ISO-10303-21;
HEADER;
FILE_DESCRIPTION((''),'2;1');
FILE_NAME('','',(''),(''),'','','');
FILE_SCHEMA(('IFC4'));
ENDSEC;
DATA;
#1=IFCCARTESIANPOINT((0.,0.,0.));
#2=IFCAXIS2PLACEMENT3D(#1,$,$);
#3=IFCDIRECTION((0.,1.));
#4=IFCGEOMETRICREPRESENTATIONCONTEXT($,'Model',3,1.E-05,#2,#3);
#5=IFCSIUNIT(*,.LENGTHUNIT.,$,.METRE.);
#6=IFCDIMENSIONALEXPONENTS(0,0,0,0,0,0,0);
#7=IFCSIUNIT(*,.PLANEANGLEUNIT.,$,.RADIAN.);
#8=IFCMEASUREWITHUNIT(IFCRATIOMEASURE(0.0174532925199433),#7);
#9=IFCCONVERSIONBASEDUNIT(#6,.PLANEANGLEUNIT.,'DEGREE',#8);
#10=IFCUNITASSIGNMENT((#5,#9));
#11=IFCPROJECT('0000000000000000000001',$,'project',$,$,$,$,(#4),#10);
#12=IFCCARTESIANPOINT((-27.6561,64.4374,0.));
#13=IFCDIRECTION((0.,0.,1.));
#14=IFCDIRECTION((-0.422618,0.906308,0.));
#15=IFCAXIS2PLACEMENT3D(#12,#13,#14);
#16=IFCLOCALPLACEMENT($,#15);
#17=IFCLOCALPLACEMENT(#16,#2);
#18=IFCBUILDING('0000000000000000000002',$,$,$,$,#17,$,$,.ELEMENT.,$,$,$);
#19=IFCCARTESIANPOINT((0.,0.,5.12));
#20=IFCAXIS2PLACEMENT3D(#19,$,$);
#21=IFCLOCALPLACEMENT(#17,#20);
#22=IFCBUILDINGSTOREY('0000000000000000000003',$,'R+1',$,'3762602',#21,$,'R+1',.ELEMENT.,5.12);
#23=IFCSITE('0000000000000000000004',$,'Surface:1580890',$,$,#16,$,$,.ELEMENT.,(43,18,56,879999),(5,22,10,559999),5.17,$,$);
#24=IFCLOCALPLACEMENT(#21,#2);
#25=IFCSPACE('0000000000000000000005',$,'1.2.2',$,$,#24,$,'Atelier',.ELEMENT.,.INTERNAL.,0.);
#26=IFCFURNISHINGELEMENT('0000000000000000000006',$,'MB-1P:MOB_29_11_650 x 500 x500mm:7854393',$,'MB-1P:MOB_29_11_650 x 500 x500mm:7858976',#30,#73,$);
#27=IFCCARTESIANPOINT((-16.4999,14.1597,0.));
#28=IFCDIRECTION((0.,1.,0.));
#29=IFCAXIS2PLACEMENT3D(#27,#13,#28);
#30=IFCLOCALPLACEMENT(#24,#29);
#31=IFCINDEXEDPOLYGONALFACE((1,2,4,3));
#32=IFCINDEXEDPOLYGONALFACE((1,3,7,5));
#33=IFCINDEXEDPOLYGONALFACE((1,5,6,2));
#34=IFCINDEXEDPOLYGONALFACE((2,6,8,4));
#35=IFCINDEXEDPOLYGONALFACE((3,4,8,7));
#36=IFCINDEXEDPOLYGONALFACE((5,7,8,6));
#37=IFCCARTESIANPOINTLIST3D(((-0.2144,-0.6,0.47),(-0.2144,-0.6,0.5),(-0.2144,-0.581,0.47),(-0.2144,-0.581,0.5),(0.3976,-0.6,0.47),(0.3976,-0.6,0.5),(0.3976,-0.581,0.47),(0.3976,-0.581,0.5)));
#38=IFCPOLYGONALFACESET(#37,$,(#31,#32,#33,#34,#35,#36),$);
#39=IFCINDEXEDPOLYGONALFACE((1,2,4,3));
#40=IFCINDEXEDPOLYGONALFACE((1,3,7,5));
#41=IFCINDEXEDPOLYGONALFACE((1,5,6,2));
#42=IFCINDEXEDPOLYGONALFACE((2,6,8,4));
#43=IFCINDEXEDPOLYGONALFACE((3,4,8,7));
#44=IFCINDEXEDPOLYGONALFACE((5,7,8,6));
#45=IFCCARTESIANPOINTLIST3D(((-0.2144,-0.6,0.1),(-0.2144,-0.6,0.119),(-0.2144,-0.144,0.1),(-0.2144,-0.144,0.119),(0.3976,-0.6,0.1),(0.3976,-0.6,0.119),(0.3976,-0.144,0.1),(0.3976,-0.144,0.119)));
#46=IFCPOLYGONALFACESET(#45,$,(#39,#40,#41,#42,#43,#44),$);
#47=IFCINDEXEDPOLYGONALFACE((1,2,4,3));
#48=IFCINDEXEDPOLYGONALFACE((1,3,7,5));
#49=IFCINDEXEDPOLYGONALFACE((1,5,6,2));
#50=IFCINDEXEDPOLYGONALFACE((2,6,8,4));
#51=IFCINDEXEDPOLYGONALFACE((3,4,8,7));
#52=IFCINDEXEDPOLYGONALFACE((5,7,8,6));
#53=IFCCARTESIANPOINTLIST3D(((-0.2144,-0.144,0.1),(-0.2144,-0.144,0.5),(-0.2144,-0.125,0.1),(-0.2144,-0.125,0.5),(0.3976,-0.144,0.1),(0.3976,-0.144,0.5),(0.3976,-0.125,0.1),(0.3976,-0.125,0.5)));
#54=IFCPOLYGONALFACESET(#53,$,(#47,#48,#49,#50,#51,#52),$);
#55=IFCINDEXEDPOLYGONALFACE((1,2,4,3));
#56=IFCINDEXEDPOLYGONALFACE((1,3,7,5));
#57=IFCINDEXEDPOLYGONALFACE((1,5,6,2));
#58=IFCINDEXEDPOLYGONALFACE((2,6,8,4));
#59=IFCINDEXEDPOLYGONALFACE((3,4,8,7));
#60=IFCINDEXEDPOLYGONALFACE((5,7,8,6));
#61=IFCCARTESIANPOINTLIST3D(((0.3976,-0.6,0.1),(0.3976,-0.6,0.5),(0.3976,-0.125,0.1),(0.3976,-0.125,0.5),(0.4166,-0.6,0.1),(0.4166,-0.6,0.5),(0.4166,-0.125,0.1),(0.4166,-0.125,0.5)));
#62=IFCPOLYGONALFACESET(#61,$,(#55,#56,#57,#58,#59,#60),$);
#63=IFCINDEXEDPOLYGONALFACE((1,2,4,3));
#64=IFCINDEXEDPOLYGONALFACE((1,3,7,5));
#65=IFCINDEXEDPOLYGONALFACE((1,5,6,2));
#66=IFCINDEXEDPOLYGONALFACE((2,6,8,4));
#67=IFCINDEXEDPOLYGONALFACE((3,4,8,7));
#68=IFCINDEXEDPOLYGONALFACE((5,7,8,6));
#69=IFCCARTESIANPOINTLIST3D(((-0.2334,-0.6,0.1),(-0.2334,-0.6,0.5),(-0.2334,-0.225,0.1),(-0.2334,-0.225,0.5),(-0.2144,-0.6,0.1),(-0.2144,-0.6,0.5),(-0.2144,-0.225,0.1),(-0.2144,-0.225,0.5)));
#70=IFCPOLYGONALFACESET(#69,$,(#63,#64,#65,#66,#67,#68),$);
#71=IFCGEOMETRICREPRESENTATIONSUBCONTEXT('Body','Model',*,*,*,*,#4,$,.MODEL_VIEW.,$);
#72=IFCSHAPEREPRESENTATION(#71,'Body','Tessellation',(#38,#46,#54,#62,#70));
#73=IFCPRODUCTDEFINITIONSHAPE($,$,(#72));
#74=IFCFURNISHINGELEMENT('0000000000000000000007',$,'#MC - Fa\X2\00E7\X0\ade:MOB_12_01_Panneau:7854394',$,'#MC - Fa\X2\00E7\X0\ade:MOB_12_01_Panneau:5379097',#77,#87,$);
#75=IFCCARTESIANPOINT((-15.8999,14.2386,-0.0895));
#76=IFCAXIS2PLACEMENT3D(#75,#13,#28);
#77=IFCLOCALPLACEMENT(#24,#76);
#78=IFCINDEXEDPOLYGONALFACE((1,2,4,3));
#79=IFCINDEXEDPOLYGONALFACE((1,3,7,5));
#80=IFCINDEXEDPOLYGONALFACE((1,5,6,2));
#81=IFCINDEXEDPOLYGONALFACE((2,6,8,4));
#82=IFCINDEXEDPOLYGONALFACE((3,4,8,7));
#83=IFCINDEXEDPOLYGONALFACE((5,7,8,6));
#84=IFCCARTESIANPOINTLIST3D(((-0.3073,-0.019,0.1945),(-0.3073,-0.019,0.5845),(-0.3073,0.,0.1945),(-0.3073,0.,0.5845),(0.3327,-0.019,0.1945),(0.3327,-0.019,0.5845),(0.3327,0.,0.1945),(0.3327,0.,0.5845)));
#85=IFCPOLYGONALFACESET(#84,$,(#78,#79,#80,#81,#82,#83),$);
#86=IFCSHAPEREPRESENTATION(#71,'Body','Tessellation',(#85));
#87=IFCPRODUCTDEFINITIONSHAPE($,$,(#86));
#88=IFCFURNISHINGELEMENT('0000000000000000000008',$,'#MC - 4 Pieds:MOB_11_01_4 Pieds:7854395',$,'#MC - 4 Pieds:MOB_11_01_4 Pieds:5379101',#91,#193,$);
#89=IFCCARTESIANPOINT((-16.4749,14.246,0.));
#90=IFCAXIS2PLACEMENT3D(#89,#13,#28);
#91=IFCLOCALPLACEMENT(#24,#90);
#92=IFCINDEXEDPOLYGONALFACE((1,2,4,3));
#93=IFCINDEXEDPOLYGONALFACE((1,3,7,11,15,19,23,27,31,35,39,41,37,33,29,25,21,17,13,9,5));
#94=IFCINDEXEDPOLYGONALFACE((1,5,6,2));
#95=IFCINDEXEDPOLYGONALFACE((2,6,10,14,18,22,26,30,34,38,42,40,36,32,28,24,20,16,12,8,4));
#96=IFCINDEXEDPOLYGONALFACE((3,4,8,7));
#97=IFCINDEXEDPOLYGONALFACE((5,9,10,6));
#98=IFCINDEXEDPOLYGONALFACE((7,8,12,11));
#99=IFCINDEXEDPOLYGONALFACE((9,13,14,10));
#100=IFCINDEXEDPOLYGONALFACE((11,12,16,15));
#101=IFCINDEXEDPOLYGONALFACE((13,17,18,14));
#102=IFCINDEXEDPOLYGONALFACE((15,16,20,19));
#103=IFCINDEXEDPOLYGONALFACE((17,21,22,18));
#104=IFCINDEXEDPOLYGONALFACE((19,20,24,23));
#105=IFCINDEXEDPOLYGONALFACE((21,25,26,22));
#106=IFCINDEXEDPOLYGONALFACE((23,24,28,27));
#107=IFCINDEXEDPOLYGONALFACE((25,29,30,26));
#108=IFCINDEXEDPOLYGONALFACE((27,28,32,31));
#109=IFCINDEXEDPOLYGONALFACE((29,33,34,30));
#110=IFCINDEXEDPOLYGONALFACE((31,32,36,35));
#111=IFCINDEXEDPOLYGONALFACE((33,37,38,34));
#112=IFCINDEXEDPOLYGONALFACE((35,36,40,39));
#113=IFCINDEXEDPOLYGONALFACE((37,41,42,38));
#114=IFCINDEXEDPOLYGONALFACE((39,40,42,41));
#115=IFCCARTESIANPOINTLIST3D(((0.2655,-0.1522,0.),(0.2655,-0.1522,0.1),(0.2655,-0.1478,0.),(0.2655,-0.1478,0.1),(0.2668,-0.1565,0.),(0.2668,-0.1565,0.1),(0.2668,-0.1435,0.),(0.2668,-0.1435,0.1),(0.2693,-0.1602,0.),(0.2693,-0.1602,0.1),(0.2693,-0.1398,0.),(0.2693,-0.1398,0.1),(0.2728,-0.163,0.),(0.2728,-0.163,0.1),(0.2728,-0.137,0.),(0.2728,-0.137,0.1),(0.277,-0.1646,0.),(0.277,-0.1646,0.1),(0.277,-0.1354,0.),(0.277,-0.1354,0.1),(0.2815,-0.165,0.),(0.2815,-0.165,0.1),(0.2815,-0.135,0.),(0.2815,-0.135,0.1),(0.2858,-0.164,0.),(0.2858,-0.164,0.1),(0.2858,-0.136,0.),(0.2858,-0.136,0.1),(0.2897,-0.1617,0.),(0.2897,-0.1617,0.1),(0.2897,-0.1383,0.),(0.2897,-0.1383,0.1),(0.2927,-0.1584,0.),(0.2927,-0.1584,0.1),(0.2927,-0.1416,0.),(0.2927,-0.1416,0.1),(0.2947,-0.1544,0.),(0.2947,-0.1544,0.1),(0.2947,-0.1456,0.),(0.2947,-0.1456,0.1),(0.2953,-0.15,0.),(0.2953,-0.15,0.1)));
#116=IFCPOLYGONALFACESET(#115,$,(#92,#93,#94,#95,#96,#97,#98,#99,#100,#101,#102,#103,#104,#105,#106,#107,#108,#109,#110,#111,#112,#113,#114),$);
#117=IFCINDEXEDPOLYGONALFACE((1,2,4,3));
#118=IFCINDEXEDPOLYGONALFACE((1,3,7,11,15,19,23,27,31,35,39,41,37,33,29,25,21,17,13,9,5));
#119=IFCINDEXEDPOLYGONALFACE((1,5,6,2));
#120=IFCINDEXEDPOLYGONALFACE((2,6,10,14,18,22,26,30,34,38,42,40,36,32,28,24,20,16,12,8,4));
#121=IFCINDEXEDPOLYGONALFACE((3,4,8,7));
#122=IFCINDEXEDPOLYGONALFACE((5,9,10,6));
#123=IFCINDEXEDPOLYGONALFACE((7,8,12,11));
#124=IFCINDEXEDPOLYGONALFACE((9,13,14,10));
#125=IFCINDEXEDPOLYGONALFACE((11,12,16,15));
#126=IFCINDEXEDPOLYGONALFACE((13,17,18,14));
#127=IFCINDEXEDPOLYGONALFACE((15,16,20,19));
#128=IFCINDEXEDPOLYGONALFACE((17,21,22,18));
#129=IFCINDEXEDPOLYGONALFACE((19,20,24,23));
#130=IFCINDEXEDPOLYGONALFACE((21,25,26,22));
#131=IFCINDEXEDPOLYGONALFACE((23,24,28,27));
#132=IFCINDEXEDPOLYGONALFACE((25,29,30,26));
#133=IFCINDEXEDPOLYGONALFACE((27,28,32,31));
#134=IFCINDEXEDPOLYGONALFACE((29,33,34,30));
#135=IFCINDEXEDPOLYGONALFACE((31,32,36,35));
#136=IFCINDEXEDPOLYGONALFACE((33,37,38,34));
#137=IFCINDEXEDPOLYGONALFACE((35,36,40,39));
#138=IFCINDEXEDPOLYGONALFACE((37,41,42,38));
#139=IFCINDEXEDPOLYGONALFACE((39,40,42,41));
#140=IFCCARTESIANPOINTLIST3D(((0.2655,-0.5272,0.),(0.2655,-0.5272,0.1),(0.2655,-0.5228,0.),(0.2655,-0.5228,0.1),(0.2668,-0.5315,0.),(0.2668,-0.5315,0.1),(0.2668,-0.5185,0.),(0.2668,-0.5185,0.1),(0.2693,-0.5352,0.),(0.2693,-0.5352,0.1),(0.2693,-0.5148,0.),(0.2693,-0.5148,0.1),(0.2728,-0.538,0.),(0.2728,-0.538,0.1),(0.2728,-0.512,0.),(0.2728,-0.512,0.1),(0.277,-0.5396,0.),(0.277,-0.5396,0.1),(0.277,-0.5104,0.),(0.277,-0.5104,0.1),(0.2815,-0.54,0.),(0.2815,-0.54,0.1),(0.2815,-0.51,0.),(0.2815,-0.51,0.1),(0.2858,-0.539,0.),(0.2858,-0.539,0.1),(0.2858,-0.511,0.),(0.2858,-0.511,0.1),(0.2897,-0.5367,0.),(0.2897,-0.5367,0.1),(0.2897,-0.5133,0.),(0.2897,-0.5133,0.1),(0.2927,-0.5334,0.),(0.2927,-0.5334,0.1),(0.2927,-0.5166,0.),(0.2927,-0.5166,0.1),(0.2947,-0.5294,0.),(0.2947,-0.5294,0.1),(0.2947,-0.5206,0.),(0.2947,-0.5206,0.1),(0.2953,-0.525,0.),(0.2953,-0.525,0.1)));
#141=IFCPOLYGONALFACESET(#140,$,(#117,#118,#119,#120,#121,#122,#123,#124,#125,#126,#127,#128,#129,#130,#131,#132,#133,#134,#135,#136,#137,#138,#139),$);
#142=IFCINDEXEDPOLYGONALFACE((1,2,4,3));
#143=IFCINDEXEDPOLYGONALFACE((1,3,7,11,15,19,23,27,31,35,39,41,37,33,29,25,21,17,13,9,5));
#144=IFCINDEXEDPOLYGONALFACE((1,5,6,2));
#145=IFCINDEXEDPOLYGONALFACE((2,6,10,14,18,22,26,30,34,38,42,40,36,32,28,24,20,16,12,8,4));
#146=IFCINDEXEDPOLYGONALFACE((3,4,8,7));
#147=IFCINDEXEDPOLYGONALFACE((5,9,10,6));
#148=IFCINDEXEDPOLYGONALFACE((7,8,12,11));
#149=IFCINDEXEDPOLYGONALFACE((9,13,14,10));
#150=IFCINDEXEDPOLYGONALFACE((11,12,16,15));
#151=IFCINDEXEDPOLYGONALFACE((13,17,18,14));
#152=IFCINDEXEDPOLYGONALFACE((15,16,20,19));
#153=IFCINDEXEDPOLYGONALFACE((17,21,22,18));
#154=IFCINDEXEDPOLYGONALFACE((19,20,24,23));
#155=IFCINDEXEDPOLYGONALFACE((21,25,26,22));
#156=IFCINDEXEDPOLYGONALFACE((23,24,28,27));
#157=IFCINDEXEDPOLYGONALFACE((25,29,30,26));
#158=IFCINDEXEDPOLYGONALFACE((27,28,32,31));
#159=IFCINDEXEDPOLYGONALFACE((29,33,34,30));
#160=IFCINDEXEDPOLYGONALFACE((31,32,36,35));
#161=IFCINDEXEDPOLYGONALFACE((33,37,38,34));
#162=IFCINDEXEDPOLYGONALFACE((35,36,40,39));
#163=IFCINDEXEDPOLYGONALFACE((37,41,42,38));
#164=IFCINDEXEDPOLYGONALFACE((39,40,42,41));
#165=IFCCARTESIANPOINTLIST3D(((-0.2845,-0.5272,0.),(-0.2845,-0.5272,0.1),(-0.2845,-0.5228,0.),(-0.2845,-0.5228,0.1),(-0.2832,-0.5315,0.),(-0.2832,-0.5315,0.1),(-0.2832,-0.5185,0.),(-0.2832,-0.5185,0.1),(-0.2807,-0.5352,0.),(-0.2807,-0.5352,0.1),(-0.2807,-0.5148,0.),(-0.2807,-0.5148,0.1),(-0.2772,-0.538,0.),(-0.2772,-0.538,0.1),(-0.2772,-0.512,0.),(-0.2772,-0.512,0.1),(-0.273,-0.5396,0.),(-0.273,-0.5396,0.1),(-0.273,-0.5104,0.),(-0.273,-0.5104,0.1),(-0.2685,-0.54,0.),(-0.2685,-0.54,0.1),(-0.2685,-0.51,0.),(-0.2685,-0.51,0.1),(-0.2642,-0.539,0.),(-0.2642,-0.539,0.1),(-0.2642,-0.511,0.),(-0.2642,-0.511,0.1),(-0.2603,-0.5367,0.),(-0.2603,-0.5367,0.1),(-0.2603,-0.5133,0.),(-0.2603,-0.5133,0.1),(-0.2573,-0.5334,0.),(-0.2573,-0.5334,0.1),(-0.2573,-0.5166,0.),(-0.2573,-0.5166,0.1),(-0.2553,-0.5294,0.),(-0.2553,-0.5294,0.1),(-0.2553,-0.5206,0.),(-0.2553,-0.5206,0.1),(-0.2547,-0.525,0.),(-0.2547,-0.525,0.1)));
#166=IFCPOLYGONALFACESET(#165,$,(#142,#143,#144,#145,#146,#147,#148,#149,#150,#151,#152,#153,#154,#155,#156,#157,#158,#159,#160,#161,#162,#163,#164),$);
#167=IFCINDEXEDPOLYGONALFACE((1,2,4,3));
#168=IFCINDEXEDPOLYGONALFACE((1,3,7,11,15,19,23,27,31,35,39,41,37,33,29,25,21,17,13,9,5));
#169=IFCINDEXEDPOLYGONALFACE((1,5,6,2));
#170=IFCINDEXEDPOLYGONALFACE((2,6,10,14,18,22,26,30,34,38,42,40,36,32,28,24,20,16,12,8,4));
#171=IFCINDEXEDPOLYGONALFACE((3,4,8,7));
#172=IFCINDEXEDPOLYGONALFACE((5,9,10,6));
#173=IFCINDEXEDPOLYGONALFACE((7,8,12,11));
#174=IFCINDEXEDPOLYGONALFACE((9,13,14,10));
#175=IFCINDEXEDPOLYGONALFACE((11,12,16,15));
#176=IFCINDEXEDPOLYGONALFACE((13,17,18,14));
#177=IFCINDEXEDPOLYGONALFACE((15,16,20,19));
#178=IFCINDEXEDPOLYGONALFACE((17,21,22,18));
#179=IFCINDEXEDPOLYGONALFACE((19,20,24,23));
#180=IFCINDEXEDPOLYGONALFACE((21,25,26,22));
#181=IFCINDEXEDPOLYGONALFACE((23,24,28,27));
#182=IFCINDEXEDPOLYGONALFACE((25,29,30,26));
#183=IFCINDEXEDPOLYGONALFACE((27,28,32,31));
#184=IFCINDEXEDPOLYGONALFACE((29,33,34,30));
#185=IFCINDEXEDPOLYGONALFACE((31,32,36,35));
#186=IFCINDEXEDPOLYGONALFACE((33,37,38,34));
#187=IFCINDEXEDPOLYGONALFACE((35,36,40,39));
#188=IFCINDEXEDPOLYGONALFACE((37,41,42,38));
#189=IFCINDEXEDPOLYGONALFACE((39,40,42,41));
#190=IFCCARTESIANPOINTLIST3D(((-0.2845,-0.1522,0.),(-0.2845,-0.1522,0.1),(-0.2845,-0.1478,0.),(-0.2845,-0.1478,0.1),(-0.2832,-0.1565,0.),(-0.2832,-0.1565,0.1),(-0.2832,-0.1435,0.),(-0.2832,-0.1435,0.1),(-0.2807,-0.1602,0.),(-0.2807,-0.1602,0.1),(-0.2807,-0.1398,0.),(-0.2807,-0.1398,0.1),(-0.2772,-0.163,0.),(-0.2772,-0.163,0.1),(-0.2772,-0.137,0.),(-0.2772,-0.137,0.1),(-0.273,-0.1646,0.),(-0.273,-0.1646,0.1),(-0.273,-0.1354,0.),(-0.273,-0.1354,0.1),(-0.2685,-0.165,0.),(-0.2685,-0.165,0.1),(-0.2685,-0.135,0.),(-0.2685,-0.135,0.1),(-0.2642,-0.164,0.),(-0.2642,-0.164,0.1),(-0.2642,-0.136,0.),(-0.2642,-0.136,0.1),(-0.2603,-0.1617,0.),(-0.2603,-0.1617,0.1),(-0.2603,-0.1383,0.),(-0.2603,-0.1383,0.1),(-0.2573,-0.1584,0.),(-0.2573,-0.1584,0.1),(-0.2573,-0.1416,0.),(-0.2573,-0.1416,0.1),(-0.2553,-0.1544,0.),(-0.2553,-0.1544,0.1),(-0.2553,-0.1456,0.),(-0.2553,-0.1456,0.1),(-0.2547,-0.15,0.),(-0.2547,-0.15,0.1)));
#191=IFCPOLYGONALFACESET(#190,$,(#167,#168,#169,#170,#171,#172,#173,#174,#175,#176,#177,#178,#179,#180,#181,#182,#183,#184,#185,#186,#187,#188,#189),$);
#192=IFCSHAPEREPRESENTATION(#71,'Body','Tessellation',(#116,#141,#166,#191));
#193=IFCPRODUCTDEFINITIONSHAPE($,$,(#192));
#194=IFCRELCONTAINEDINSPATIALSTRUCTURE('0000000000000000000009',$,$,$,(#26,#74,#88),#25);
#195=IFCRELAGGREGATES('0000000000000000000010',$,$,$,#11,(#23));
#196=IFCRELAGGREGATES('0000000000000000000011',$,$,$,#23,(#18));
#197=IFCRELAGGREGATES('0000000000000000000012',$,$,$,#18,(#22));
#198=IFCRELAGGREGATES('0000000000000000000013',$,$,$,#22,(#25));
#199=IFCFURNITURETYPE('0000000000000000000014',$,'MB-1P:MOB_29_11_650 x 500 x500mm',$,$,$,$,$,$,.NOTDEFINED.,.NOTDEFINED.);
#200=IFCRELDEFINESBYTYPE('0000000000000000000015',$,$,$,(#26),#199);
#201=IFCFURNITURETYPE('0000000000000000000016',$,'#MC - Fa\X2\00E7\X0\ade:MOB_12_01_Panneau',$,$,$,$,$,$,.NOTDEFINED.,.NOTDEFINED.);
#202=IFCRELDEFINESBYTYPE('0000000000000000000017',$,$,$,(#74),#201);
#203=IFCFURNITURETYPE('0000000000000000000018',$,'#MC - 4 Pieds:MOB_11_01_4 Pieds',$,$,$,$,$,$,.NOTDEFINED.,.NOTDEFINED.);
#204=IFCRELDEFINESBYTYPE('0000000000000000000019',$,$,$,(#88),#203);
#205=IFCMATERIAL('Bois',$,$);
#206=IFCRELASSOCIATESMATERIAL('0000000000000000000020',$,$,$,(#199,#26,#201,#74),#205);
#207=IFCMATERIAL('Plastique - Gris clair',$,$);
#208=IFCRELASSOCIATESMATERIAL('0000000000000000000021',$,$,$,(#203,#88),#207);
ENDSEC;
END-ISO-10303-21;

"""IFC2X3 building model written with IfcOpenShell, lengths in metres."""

from ifc_helpers import new_model, entity, si_unit, converted_unit, direction, frame, frame_2d, origin, origin_2d_with_axis, place, context, subcontext, project, spatial, rectangle, circle, extrude, source, transform, mapped, material, type_object, type_shapes, element, save


model = new_model("IFC2X3")

# Units and contexts
model_context = context("Model", 3, precision=1e-05, world=origin(), true_north=direction((0.0, 1.0)))
body_context = subcontext(model_context, "Body", "Model", "MODEL_VIEW")
ifc_project = project(units=[si_unit("LENGTHUNIT", "METRE"), converted_unit("PLANEANGLEUNIT", "DEGREE", entity("IfcRatioMeasure", 0.0174532925199433), si_unit("PLANEANGLEUNIT", "RADIAN"), dimensions=[0, 0, 0, 0, 0, 0, 0])], contexts=[model_context])

# Site, building, storey
site_placement = place(None, frame((-27.6561, 64.4374, 0.0), z_axis=(0.0, 0.0, 1.0), x_axis=(-0.422618, 0.906308, 0.0)))
site = spatial("IfcSite", under=ifc_project, at=site_placement, Name="Surface:1580890", CompositionType="ELEMENT", RefLatitude=(43, 18, 56, 879999), RefLongitude=(5, 22, 10, 559999), RefElevation=5.17)
building_placement = place(site_placement, origin())
building = spatial("IfcBuilding", under=site, at=building_placement, CompositionType="ELEMENT")
storey_placement = place(building_placement, frame((0.0, 0.0, 5.12)))
storey = spatial("IfcBuildingStorey", under=building, at=storey_placement, Name="R+1", ObjectType="3762602", LongName="R+1", CompositionType="ELEMENT", Elevation=5.12)

# Shared definitions
space_placement = place(storey_placement, origin())
space = spatial("IfcSpace", under=storey, at=space_placement, Name="1.2.2", LongName="Atelier", CompositionType="ELEMENT", InteriorOrExteriorSpace="INTERNAL", ElevationWithFlooring=0.0)

# Furnishing elements
ifc_material_1 = material(Name="Plastique - Gris clair")
ifc_material_2 = material(Name="Bois")
furniture_type_1 = type_object("IfcFurnitureType", Name="MB-1P:MOB_29_11_650 x 500 x500mm", material=ifc_material_2)
shared_shape_1 = source(origin(), body_context, "Body", "SweptSolid", [
    extrude(rectangle(XDim=0.612, YDim=0.019, at=origin_2d_with_axis()), frame((0.0916, -0.5905, 0.47), z_axis=(0.0, 0.0, 1.0), x_axis=(-1.0, 0.0, 0.0)), (0.0, 0.0, 1.0), 0.03),
    extrude(rectangle(XDim=0.456, YDim=0.612, at=frame_2d((0.0, 0.0), x_axis=(1.0, 0.0))), frame((0.0916, -0.372, 0.1), z_axis=(0.0, 0.0, 1.0), x_axis=(0.0, 1.0, 0.0)), (0.0, 0.0, 1.0), 0.019),
    extrude(rectangle(XDim=0.612, YDim=0.019, at=origin_2d_with_axis()), frame((0.0916, -0.1345, 0.1), z_axis=(0.0, 0.0, 1.0), x_axis=(-1.0, 0.0, 0.0)), (0.0, 0.0, 1.0), 0.4),
    extrude(rectangle(XDim=0.475, YDim=0.019, at=origin_2d_with_axis()), frame((0.4071, -0.3625, 0.1), z_axis=(0.0, 0.0, 1.0), x_axis=(0.0, 1.0, 0.0)), (0.0, 0.0, 1.0), 0.4),
    extrude(rectangle(XDim=0.375, YDim=0.019, at=origin_2d_with_axis()), frame((-0.2239, -0.4125, 0.1), z_axis=(0.0, 0.0, 1.0), x_axis=(0.0, 1.0, 0.0)), (0.0, 0.0, 1.0), 0.4),
])
type_shapes(furniture_type_1, [shared_shape_1])
furnishing_1_placement = place(space_placement, frame((-16.4999, 14.1597, 0.0), z_axis=(0.0, 0.0, 1.0), x_axis=(0.0, 1.0, 0.0)))
element("IfcFurnishingElement", 1, at=furnishing_1_placement, inside=space, type_object=furniture_type_1, material=ifc_material_2, Name="MB-1P:MOB_29_11_650 x 500 x500mm:7854393", ObjectType="MB-1P:MOB_29_11_650 x 500 x500mm:7858976", context=body_context, shape_type="MappedRepresentation", body=[
    mapped(shared_shape_1, transform((0.0, 0.0, 0.0), scale=1.0)),
])
furniture_type_2 = type_object("IfcFurnitureType", Name="#MC - Façade:MOB_12_01_Panneau", material=ifc_material_2)
shared_shape_2 = source(origin(), body_context, "Body", "SweptSolid", [
    extrude(rectangle(XDim=0.64, YDim=0.019, at=origin_2d_with_axis()), frame((0.0127, -0.0095, 0.1945), z_axis=(0.0, 0.0, 1.0), x_axis=(-1.0, 0.0, 0.0)), (0.0, 0.0, 1.0), 0.39),
])
type_shapes(furniture_type_2, [shared_shape_2])
furnishing_2_placement = place(space_placement, frame((-15.8999, 14.2386, -0.0895), z_axis=(0.0, 0.0, 1.0), x_axis=(0.0, 1.0, 0.0)))
element("IfcFurnishingElement", 2, at=furnishing_2_placement, inside=space, type_object=furniture_type_2, material=ifc_material_2, Name="#MC - Façade:MOB_12_01_Panneau:7854394", ObjectType="#MC - Façade:MOB_12_01_Panneau:5379097", context=body_context, shape_type="MappedRepresentation", body=[
    mapped(shared_shape_2, transform((0.0, 0.0, 0.0), scale=1.0)),
])
furniture_type_3 = type_object("IfcFurnitureType", Name="#MC - 4 Pieds:MOB_11_01_4 Pieds", material=ifc_material_1)
shared_shape_3 = source(origin(), body_context, "Body", "SweptSolid", [
    extrude(circle(Radius=0.015, at=frame_2d((0.0, 0.0), x_axis=(1.0, 0.0))), frame((0.2803, -0.15, 0.0)), (0.0, 0.0, 1.0), 0.1),
    extrude(circle(Radius=0.015, at=frame_2d((0.0, 0.0), x_axis=(1.0, 0.0))), frame((0.2803, -0.525, 0.0)), (0.0, 0.0, 1.0), 0.1),
    extrude(circle(Radius=0.015, at=origin_2d_with_axis()), frame((-0.2697, -0.525, 0.0)), (0.0, 0.0, 1.0), 0.1),
    extrude(circle(Radius=0.015, at=frame_2d((0.0, 0.0), x_axis=(1.0, 0.0))), frame((-0.2697, -0.15, 0.0)), (0.0, 0.0, 1.0), 0.1),
])
type_shapes(furniture_type_3, [shared_shape_3])
furnishing_3_placement = place(space_placement, frame((-16.4749, 14.246, 0.0), z_axis=(0.0, 0.0, 1.0), x_axis=(0.0, 1.0, 0.0)))
element("IfcFurnishingElement", 3, at=furnishing_3_placement, inside=space, type_object=furniture_type_3, material=ifc_material_1, Name="#MC - 4 Pieds:MOB_11_01_4 Pieds:7854395", ObjectType="#MC - 4 Pieds:MOB_11_01_4 Pieds:5379101", context=body_context, shape_type="MappedRepresentation", body=[
    mapped(shared_shape_3, transform((0.0, 0.0, 0.0), scale=1.0)),
])

save(model, "model.ifc")
